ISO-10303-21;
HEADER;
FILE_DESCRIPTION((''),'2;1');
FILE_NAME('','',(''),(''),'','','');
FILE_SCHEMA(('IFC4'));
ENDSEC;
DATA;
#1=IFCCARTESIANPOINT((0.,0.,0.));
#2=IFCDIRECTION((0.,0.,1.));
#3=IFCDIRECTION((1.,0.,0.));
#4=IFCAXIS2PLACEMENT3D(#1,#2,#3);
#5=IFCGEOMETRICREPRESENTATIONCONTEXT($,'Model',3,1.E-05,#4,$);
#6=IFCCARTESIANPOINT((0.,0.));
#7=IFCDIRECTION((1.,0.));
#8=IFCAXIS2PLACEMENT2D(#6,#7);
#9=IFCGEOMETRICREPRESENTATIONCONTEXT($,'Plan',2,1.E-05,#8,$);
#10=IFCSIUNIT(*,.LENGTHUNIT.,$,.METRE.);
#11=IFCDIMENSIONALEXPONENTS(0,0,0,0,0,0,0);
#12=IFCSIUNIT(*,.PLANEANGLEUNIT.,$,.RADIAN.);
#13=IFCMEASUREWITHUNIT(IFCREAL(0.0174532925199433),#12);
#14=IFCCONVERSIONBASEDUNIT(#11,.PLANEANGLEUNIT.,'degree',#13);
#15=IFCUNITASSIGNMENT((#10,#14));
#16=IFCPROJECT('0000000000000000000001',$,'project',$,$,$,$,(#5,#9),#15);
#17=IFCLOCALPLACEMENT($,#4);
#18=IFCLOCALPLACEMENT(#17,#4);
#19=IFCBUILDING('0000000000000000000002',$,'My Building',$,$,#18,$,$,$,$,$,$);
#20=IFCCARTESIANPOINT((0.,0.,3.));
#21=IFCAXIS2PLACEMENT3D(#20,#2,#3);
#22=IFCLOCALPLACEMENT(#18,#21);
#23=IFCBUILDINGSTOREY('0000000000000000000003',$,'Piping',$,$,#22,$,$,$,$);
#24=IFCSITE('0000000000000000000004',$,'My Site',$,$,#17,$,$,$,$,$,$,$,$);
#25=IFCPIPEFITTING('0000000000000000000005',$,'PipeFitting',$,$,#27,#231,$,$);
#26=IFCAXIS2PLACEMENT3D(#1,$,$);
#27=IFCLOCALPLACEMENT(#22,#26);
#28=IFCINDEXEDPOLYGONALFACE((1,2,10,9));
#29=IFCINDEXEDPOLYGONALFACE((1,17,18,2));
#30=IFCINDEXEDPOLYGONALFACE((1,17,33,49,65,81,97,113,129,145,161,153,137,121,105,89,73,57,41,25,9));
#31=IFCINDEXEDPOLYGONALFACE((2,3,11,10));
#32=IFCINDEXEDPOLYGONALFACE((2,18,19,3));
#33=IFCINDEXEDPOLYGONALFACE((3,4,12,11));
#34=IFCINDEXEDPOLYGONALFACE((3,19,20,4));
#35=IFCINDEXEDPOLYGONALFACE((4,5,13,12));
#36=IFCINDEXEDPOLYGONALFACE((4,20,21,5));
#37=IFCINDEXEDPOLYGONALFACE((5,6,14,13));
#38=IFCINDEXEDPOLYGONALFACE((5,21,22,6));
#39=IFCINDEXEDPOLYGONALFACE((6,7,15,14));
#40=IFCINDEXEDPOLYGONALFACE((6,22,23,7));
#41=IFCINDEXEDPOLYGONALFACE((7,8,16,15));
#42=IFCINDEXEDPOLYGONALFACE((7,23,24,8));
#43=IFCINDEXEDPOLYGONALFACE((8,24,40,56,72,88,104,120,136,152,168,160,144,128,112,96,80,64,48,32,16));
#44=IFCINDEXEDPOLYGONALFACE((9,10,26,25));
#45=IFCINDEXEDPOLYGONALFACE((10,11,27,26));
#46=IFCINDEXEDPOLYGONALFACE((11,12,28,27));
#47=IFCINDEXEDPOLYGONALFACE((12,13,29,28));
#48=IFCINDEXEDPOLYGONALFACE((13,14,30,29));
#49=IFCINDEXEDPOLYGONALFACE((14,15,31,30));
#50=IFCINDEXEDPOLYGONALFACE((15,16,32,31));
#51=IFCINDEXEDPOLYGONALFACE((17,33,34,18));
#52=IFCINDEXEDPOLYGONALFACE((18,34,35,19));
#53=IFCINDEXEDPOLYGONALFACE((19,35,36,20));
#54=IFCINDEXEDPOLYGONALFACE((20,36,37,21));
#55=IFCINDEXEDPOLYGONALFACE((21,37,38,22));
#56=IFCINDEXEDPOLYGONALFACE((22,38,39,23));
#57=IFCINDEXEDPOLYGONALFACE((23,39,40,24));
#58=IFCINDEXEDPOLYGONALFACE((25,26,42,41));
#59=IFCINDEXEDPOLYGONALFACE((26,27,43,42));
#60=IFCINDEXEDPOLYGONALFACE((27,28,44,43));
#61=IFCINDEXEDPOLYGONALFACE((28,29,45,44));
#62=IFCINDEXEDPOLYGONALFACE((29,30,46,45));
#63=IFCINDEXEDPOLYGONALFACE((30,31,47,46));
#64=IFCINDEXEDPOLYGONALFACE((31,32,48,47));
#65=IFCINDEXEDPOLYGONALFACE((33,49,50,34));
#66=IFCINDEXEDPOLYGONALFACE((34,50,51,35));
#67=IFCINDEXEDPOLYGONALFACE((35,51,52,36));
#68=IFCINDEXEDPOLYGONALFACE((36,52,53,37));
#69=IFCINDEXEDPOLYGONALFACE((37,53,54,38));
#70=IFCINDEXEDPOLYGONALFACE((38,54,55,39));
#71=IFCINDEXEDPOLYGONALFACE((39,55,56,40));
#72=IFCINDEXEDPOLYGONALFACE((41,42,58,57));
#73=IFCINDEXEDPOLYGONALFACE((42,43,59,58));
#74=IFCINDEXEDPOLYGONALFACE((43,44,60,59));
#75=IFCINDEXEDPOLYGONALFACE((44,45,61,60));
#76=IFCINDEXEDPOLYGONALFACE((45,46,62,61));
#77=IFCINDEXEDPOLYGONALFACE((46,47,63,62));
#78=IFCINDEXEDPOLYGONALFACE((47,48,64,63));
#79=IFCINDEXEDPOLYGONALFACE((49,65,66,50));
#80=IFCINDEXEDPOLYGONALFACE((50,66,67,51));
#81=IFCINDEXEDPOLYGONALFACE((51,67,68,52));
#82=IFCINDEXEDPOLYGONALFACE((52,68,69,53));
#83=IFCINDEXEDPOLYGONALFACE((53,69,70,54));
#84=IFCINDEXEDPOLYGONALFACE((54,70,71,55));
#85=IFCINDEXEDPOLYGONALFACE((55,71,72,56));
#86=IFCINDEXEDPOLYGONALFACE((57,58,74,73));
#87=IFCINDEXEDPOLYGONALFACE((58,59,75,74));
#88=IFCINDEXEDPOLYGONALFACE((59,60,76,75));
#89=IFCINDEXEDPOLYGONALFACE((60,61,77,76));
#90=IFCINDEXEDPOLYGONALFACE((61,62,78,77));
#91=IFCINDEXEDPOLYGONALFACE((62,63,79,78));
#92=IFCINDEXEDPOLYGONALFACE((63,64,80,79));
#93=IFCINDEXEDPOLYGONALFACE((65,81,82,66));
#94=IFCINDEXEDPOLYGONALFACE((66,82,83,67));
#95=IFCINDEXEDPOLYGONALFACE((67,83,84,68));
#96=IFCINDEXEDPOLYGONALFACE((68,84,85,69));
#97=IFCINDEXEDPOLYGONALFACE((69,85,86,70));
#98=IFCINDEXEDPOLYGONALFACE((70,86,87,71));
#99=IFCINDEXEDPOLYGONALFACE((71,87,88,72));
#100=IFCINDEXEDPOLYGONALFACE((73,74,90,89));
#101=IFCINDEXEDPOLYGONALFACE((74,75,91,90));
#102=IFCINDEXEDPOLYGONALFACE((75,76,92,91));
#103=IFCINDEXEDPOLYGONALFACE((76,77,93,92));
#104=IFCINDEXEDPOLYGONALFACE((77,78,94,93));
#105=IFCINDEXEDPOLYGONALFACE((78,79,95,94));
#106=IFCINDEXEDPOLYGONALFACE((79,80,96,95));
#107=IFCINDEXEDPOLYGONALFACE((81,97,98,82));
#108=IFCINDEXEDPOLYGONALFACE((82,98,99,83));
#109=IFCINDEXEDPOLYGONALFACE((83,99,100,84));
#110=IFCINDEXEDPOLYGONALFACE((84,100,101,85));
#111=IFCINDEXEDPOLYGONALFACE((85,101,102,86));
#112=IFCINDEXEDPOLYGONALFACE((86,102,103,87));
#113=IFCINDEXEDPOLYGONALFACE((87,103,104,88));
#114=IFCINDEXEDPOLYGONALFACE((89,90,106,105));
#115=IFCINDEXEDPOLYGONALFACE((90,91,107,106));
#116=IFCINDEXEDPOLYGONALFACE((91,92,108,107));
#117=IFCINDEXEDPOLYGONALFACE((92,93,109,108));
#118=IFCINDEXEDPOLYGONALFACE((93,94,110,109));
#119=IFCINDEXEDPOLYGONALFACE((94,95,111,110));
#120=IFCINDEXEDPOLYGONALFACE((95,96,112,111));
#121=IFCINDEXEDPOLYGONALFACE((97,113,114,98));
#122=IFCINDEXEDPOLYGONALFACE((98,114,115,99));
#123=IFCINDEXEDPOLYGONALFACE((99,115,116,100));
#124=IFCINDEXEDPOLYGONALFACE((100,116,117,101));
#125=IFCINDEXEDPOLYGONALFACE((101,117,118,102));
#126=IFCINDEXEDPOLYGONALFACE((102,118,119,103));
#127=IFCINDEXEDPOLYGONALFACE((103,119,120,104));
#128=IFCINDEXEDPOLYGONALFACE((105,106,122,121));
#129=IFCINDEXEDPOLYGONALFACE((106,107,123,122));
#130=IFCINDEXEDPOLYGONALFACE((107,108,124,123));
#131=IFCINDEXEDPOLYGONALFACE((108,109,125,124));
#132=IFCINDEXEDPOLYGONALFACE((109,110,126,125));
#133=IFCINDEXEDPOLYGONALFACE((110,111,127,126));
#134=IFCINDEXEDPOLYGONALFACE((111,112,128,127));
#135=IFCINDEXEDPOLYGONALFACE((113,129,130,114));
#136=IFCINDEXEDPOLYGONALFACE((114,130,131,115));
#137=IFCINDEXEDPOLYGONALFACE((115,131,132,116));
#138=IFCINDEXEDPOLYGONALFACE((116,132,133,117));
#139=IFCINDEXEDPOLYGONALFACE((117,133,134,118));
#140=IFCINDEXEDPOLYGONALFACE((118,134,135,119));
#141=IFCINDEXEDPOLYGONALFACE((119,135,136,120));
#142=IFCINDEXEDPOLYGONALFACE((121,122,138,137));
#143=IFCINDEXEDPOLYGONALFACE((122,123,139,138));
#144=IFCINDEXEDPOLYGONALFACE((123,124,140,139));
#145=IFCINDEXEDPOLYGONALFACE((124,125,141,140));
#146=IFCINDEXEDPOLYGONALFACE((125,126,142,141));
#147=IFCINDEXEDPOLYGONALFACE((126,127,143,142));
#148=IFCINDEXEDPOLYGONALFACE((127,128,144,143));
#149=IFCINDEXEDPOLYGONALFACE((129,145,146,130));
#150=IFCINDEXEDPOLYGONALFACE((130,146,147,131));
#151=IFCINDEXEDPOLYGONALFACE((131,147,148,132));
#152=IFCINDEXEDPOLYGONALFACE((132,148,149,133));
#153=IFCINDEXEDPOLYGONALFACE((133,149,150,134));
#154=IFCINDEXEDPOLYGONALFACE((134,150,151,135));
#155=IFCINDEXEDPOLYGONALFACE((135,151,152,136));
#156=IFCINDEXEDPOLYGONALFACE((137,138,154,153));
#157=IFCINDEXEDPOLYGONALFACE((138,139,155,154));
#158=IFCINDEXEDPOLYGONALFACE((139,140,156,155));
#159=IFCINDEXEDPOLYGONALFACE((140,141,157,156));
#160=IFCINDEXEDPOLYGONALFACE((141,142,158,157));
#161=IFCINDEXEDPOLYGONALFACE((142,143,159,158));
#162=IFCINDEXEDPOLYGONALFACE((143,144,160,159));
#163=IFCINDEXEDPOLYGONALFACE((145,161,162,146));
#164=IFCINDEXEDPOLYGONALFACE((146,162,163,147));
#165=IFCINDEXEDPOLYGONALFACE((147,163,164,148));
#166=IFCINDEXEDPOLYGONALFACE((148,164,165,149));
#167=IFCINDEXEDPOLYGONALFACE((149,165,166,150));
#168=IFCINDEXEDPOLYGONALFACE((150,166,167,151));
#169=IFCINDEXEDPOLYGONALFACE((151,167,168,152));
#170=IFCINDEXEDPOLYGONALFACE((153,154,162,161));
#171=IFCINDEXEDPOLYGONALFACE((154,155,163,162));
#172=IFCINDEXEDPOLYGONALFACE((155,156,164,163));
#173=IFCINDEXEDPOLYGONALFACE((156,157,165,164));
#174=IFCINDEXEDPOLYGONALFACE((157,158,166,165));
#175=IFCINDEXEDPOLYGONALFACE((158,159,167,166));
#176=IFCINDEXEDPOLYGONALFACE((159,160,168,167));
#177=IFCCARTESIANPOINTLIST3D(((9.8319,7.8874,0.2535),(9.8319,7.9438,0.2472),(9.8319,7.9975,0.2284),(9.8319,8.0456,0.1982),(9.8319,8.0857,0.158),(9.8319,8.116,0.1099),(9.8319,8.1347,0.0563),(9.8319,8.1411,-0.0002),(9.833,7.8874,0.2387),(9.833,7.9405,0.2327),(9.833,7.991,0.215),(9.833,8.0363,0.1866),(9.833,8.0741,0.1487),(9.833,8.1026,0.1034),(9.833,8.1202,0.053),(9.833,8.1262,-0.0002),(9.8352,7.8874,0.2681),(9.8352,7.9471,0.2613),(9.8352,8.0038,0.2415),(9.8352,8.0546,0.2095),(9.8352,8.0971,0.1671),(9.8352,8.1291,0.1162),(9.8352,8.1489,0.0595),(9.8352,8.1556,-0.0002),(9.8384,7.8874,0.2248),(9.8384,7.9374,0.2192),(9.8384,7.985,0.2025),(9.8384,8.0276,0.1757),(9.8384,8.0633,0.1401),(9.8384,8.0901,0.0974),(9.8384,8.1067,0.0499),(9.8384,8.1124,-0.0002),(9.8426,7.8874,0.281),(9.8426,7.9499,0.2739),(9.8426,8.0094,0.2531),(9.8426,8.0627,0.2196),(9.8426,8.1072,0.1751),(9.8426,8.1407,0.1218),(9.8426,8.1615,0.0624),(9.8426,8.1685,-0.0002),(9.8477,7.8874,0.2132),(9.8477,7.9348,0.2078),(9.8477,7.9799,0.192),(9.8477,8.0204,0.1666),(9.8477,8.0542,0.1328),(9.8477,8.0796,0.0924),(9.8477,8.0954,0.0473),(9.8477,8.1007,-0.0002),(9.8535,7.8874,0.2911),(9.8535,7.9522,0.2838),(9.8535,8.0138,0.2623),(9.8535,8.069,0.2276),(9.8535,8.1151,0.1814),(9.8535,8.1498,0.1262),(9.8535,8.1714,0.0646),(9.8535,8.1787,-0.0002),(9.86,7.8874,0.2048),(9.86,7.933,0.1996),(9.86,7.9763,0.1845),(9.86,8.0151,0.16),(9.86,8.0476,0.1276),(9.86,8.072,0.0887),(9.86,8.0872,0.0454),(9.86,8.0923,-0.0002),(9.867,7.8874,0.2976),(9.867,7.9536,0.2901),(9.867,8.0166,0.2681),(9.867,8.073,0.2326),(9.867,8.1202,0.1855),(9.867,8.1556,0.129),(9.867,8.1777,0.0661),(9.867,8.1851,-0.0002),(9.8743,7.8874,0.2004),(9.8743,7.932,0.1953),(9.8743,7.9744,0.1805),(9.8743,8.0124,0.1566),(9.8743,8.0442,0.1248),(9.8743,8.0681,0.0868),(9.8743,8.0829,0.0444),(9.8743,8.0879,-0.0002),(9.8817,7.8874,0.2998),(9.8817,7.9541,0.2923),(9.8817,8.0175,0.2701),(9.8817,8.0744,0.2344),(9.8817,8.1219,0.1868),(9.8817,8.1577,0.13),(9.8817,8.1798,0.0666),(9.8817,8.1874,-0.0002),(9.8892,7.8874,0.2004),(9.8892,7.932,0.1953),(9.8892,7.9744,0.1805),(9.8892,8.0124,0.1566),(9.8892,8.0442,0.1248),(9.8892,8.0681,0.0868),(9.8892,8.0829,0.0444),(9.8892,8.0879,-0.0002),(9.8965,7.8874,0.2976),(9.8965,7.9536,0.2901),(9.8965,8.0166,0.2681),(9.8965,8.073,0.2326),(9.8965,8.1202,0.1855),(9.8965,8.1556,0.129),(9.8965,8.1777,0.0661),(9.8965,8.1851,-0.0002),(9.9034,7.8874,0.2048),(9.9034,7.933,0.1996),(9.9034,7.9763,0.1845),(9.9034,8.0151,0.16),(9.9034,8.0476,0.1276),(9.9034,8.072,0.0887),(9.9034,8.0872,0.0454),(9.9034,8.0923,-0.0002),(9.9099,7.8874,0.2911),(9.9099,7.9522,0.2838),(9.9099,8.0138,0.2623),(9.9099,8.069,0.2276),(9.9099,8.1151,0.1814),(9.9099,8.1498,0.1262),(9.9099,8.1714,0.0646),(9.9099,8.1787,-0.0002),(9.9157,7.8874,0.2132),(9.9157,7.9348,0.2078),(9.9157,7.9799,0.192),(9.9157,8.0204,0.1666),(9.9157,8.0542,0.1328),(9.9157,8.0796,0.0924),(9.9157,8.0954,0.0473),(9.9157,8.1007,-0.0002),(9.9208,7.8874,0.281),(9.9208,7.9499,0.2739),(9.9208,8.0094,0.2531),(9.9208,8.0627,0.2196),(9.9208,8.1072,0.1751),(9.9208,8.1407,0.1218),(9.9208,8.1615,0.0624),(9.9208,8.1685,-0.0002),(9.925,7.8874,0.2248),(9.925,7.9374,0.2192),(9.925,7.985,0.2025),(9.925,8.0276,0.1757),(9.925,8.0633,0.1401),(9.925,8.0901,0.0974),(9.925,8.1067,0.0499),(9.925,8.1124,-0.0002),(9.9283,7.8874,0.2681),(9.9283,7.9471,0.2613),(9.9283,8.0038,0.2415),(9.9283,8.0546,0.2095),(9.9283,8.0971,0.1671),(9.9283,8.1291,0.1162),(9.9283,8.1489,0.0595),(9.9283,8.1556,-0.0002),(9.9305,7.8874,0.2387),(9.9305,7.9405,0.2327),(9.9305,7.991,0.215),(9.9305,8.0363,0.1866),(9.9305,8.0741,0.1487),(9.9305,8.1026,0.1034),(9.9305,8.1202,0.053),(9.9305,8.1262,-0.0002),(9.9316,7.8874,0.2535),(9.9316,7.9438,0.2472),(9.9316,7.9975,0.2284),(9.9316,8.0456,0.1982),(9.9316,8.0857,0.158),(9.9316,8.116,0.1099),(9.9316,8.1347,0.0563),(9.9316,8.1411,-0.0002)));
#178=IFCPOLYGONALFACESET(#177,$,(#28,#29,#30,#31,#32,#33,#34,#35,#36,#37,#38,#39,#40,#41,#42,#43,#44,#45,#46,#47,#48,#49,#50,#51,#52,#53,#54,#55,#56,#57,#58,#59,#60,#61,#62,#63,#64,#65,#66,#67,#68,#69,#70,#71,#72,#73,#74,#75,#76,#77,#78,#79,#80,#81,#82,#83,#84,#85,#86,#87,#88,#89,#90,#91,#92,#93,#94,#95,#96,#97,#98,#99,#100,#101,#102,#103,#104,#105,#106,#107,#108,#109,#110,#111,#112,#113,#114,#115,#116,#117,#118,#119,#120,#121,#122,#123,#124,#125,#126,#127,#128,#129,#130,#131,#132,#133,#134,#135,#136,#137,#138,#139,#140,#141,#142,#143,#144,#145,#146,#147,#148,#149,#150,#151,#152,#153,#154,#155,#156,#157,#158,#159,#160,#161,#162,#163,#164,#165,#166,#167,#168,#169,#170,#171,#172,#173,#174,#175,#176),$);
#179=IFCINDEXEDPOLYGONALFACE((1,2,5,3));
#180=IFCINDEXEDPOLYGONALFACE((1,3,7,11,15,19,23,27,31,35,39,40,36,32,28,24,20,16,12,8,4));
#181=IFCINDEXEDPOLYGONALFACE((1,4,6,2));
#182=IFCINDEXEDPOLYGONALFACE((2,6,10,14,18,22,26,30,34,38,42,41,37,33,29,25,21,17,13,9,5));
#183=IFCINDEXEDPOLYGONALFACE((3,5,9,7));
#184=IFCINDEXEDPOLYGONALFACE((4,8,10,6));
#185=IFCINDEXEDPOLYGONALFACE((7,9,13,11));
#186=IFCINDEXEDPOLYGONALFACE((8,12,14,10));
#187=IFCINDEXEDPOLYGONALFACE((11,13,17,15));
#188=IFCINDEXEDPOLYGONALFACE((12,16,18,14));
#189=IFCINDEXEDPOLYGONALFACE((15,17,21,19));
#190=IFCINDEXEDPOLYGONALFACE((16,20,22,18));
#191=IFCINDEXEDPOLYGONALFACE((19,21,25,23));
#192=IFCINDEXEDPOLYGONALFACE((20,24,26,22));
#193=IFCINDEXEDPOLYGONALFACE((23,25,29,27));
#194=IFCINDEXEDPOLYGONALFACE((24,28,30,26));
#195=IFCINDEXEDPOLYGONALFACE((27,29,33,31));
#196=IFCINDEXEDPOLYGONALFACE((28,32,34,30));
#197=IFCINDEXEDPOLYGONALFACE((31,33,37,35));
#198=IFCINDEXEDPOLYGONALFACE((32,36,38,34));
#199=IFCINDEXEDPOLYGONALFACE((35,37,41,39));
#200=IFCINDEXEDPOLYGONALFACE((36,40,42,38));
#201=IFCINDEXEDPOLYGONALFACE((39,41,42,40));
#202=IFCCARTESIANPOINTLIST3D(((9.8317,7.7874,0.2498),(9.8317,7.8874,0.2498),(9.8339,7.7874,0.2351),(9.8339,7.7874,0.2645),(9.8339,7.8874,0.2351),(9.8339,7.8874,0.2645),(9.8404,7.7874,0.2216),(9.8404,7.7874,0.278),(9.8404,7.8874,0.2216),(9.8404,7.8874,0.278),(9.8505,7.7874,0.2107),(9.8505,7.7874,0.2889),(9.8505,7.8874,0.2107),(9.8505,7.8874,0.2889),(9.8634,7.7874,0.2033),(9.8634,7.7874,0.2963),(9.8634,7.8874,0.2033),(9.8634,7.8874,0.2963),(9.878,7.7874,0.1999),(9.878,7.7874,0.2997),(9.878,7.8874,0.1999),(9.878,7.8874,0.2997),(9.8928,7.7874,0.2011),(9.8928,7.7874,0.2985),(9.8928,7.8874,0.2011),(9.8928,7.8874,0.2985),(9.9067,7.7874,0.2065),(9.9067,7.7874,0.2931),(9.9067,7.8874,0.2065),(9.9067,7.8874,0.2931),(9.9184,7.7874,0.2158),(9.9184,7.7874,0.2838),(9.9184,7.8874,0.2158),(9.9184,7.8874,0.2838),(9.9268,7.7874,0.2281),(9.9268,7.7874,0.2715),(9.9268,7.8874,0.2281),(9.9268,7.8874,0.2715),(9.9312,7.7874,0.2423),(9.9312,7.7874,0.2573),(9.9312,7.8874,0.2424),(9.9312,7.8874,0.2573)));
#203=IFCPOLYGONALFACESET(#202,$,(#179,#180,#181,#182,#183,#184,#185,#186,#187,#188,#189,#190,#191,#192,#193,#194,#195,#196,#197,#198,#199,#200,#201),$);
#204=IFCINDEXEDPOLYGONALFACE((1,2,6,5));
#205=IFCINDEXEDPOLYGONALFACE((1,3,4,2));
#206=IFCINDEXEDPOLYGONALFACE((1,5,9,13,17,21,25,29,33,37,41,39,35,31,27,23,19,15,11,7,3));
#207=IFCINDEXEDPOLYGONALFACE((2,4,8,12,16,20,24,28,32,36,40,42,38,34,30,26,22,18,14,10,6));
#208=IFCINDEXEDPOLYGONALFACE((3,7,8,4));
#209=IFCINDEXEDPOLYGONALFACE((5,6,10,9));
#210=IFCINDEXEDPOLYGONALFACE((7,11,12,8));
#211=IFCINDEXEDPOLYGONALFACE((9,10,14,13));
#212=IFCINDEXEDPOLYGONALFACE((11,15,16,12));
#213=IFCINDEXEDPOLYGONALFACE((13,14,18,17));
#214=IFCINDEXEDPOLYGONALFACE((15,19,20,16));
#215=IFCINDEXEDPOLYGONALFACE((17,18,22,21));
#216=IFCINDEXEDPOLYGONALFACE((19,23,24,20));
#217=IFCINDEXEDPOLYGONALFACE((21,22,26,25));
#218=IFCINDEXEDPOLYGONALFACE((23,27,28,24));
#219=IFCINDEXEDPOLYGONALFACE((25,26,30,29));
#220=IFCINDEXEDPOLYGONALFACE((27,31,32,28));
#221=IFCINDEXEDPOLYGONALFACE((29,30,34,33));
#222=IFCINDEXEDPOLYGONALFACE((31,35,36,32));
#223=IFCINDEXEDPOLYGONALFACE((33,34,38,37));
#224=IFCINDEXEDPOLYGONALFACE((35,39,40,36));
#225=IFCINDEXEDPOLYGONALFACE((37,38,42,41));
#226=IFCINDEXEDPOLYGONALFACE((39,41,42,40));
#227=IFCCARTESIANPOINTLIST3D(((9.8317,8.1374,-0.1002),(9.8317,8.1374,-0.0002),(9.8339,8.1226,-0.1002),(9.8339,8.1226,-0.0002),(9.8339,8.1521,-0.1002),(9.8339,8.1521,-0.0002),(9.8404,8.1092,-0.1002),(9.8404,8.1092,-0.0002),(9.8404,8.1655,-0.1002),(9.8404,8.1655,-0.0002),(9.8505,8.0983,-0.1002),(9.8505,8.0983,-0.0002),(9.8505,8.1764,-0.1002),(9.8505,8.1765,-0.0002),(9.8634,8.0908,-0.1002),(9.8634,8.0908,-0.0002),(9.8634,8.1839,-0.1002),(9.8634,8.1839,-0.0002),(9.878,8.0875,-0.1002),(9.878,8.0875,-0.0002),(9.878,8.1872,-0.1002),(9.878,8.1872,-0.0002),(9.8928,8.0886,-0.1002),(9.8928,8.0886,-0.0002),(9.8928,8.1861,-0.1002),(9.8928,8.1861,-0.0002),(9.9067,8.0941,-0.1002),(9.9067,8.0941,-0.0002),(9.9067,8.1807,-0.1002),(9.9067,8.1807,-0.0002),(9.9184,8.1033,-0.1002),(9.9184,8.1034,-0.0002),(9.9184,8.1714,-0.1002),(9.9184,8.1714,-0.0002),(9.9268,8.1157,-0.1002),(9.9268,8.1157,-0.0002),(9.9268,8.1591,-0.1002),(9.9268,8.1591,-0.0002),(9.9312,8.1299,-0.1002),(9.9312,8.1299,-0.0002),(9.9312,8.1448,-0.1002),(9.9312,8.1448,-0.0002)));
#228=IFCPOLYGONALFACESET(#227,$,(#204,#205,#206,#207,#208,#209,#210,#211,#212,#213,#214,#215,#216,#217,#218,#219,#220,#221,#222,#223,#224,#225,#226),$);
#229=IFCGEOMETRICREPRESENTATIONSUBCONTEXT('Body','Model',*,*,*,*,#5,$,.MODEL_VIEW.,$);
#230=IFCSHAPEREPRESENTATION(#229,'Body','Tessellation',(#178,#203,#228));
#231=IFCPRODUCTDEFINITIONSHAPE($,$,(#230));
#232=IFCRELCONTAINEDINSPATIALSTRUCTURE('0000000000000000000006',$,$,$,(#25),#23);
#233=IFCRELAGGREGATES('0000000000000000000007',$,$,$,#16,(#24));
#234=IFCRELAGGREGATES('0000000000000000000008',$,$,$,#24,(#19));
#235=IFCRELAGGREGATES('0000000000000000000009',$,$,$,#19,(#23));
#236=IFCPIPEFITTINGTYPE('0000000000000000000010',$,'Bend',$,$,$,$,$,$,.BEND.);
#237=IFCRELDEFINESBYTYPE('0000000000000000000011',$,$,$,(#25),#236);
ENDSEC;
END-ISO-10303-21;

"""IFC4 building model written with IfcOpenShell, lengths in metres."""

from ifc_helpers import new_model, entity, si_unit, converted_unit, frame, origin_with_axes, origin_2d_with_axis, place, context, subcontext, project, spatial, circle, extrude, source, transform, mapped, type_object, type_shapes, element, save


model = new_model("IFC4")

# Units and contexts
model_context = context("Model", 3, precision=1e-05, world=origin_with_axes())
plan_context = context("Plan", 2, precision=1e-05, world=origin_2d_with_axis())
body_context = subcontext(model_context, "Body", "Model", "MODEL_VIEW")
ifc_project = project(units=[si_unit("LENGTHUNIT", "METRE"), converted_unit("PLANEANGLEUNIT", "degree", entity("IfcReal", 0.0174532925199433), si_unit("PLANEANGLEUNIT", "RADIAN"), dimensions=[0, 0, 0, 0, 0, 0, 0])], contexts=[model_context, plan_context])

# Site, building, storey
site_placement = place(None, origin_with_axes())
site = spatial("IfcSite", under=ifc_project, at=site_placement, Name="My Site")
building_placement = place(site_placement, origin_with_axes())
building = spatial("IfcBuilding", under=site, at=building_placement, Name="My Building")
storey_placement = place(building_placement, frame((0.0, 0.0, 3.0), z_axis=(0.0, 0.0, 1.0), x_axis=(1.0, 0.0, 0.0)))
storey = spatial("IfcBuildingStorey", under=building, at=storey_placement, Name="Piping")

# Pipe fitting
pipe_fitting_type_1 = type_object("IfcPipeFittingType", Name="Bend", PredefinedType="BEND")
shared_shape = source(origin_with_axes(), body_context, "Body", "SolidModel", [
    entity("IfcSweptDiskSolid", entity("IfcIndexedPolyCurve", entity("IfcCartesianPointList3D", [[0.0, 0.0, 0.1], [0.0, -0.0732, 0.2768], [0.0, -0.25, 0.35]]), [entity("IfcArcIndex", [1, 2, 3])]), 0.05),
    extrude(circle(Radius=0.05), origin_with_axes(), (0.0, 0.0, 1.0), 0.1),
    extrude(circle(Radius=0.05), frame((0.0, -0.25, 0.35), z_axis=(0.0, -1.0, -0.00003), x_axis=(1.0, 0.0, 0.0)), (0.0, 0.0, 1.0), 0.1),
])
type_shapes(pipe_fitting_type_1, [shared_shape])
for number, where, z_axis, x_axis, name in (
    (1, (9.8817, 7.7874, 0.2498), (0.0, 1.0, 0.000008), (-1.0, 0.0, 0.0), "PipeFitting"),
):
    element("IfcPipeFitting", number, at=place(storey_placement, frame(where, z_axis=z_axis, x_axis=x_axis)), inside=storey, type_object=pipe_fitting_type_1, Name=name, context=body_context, shape_type="MappedRepresentation", body=[
        mapped(shared_shape, transform((0.0, 0.0, 0.0), x_axis=(1.0, 0.0, 0.0), y_axis=(0.0, 1.0, 0.0), z_axis=(0.0, 0.0, 1.0), scale=1.0)),
    ])

save(model, "model.ifc")
